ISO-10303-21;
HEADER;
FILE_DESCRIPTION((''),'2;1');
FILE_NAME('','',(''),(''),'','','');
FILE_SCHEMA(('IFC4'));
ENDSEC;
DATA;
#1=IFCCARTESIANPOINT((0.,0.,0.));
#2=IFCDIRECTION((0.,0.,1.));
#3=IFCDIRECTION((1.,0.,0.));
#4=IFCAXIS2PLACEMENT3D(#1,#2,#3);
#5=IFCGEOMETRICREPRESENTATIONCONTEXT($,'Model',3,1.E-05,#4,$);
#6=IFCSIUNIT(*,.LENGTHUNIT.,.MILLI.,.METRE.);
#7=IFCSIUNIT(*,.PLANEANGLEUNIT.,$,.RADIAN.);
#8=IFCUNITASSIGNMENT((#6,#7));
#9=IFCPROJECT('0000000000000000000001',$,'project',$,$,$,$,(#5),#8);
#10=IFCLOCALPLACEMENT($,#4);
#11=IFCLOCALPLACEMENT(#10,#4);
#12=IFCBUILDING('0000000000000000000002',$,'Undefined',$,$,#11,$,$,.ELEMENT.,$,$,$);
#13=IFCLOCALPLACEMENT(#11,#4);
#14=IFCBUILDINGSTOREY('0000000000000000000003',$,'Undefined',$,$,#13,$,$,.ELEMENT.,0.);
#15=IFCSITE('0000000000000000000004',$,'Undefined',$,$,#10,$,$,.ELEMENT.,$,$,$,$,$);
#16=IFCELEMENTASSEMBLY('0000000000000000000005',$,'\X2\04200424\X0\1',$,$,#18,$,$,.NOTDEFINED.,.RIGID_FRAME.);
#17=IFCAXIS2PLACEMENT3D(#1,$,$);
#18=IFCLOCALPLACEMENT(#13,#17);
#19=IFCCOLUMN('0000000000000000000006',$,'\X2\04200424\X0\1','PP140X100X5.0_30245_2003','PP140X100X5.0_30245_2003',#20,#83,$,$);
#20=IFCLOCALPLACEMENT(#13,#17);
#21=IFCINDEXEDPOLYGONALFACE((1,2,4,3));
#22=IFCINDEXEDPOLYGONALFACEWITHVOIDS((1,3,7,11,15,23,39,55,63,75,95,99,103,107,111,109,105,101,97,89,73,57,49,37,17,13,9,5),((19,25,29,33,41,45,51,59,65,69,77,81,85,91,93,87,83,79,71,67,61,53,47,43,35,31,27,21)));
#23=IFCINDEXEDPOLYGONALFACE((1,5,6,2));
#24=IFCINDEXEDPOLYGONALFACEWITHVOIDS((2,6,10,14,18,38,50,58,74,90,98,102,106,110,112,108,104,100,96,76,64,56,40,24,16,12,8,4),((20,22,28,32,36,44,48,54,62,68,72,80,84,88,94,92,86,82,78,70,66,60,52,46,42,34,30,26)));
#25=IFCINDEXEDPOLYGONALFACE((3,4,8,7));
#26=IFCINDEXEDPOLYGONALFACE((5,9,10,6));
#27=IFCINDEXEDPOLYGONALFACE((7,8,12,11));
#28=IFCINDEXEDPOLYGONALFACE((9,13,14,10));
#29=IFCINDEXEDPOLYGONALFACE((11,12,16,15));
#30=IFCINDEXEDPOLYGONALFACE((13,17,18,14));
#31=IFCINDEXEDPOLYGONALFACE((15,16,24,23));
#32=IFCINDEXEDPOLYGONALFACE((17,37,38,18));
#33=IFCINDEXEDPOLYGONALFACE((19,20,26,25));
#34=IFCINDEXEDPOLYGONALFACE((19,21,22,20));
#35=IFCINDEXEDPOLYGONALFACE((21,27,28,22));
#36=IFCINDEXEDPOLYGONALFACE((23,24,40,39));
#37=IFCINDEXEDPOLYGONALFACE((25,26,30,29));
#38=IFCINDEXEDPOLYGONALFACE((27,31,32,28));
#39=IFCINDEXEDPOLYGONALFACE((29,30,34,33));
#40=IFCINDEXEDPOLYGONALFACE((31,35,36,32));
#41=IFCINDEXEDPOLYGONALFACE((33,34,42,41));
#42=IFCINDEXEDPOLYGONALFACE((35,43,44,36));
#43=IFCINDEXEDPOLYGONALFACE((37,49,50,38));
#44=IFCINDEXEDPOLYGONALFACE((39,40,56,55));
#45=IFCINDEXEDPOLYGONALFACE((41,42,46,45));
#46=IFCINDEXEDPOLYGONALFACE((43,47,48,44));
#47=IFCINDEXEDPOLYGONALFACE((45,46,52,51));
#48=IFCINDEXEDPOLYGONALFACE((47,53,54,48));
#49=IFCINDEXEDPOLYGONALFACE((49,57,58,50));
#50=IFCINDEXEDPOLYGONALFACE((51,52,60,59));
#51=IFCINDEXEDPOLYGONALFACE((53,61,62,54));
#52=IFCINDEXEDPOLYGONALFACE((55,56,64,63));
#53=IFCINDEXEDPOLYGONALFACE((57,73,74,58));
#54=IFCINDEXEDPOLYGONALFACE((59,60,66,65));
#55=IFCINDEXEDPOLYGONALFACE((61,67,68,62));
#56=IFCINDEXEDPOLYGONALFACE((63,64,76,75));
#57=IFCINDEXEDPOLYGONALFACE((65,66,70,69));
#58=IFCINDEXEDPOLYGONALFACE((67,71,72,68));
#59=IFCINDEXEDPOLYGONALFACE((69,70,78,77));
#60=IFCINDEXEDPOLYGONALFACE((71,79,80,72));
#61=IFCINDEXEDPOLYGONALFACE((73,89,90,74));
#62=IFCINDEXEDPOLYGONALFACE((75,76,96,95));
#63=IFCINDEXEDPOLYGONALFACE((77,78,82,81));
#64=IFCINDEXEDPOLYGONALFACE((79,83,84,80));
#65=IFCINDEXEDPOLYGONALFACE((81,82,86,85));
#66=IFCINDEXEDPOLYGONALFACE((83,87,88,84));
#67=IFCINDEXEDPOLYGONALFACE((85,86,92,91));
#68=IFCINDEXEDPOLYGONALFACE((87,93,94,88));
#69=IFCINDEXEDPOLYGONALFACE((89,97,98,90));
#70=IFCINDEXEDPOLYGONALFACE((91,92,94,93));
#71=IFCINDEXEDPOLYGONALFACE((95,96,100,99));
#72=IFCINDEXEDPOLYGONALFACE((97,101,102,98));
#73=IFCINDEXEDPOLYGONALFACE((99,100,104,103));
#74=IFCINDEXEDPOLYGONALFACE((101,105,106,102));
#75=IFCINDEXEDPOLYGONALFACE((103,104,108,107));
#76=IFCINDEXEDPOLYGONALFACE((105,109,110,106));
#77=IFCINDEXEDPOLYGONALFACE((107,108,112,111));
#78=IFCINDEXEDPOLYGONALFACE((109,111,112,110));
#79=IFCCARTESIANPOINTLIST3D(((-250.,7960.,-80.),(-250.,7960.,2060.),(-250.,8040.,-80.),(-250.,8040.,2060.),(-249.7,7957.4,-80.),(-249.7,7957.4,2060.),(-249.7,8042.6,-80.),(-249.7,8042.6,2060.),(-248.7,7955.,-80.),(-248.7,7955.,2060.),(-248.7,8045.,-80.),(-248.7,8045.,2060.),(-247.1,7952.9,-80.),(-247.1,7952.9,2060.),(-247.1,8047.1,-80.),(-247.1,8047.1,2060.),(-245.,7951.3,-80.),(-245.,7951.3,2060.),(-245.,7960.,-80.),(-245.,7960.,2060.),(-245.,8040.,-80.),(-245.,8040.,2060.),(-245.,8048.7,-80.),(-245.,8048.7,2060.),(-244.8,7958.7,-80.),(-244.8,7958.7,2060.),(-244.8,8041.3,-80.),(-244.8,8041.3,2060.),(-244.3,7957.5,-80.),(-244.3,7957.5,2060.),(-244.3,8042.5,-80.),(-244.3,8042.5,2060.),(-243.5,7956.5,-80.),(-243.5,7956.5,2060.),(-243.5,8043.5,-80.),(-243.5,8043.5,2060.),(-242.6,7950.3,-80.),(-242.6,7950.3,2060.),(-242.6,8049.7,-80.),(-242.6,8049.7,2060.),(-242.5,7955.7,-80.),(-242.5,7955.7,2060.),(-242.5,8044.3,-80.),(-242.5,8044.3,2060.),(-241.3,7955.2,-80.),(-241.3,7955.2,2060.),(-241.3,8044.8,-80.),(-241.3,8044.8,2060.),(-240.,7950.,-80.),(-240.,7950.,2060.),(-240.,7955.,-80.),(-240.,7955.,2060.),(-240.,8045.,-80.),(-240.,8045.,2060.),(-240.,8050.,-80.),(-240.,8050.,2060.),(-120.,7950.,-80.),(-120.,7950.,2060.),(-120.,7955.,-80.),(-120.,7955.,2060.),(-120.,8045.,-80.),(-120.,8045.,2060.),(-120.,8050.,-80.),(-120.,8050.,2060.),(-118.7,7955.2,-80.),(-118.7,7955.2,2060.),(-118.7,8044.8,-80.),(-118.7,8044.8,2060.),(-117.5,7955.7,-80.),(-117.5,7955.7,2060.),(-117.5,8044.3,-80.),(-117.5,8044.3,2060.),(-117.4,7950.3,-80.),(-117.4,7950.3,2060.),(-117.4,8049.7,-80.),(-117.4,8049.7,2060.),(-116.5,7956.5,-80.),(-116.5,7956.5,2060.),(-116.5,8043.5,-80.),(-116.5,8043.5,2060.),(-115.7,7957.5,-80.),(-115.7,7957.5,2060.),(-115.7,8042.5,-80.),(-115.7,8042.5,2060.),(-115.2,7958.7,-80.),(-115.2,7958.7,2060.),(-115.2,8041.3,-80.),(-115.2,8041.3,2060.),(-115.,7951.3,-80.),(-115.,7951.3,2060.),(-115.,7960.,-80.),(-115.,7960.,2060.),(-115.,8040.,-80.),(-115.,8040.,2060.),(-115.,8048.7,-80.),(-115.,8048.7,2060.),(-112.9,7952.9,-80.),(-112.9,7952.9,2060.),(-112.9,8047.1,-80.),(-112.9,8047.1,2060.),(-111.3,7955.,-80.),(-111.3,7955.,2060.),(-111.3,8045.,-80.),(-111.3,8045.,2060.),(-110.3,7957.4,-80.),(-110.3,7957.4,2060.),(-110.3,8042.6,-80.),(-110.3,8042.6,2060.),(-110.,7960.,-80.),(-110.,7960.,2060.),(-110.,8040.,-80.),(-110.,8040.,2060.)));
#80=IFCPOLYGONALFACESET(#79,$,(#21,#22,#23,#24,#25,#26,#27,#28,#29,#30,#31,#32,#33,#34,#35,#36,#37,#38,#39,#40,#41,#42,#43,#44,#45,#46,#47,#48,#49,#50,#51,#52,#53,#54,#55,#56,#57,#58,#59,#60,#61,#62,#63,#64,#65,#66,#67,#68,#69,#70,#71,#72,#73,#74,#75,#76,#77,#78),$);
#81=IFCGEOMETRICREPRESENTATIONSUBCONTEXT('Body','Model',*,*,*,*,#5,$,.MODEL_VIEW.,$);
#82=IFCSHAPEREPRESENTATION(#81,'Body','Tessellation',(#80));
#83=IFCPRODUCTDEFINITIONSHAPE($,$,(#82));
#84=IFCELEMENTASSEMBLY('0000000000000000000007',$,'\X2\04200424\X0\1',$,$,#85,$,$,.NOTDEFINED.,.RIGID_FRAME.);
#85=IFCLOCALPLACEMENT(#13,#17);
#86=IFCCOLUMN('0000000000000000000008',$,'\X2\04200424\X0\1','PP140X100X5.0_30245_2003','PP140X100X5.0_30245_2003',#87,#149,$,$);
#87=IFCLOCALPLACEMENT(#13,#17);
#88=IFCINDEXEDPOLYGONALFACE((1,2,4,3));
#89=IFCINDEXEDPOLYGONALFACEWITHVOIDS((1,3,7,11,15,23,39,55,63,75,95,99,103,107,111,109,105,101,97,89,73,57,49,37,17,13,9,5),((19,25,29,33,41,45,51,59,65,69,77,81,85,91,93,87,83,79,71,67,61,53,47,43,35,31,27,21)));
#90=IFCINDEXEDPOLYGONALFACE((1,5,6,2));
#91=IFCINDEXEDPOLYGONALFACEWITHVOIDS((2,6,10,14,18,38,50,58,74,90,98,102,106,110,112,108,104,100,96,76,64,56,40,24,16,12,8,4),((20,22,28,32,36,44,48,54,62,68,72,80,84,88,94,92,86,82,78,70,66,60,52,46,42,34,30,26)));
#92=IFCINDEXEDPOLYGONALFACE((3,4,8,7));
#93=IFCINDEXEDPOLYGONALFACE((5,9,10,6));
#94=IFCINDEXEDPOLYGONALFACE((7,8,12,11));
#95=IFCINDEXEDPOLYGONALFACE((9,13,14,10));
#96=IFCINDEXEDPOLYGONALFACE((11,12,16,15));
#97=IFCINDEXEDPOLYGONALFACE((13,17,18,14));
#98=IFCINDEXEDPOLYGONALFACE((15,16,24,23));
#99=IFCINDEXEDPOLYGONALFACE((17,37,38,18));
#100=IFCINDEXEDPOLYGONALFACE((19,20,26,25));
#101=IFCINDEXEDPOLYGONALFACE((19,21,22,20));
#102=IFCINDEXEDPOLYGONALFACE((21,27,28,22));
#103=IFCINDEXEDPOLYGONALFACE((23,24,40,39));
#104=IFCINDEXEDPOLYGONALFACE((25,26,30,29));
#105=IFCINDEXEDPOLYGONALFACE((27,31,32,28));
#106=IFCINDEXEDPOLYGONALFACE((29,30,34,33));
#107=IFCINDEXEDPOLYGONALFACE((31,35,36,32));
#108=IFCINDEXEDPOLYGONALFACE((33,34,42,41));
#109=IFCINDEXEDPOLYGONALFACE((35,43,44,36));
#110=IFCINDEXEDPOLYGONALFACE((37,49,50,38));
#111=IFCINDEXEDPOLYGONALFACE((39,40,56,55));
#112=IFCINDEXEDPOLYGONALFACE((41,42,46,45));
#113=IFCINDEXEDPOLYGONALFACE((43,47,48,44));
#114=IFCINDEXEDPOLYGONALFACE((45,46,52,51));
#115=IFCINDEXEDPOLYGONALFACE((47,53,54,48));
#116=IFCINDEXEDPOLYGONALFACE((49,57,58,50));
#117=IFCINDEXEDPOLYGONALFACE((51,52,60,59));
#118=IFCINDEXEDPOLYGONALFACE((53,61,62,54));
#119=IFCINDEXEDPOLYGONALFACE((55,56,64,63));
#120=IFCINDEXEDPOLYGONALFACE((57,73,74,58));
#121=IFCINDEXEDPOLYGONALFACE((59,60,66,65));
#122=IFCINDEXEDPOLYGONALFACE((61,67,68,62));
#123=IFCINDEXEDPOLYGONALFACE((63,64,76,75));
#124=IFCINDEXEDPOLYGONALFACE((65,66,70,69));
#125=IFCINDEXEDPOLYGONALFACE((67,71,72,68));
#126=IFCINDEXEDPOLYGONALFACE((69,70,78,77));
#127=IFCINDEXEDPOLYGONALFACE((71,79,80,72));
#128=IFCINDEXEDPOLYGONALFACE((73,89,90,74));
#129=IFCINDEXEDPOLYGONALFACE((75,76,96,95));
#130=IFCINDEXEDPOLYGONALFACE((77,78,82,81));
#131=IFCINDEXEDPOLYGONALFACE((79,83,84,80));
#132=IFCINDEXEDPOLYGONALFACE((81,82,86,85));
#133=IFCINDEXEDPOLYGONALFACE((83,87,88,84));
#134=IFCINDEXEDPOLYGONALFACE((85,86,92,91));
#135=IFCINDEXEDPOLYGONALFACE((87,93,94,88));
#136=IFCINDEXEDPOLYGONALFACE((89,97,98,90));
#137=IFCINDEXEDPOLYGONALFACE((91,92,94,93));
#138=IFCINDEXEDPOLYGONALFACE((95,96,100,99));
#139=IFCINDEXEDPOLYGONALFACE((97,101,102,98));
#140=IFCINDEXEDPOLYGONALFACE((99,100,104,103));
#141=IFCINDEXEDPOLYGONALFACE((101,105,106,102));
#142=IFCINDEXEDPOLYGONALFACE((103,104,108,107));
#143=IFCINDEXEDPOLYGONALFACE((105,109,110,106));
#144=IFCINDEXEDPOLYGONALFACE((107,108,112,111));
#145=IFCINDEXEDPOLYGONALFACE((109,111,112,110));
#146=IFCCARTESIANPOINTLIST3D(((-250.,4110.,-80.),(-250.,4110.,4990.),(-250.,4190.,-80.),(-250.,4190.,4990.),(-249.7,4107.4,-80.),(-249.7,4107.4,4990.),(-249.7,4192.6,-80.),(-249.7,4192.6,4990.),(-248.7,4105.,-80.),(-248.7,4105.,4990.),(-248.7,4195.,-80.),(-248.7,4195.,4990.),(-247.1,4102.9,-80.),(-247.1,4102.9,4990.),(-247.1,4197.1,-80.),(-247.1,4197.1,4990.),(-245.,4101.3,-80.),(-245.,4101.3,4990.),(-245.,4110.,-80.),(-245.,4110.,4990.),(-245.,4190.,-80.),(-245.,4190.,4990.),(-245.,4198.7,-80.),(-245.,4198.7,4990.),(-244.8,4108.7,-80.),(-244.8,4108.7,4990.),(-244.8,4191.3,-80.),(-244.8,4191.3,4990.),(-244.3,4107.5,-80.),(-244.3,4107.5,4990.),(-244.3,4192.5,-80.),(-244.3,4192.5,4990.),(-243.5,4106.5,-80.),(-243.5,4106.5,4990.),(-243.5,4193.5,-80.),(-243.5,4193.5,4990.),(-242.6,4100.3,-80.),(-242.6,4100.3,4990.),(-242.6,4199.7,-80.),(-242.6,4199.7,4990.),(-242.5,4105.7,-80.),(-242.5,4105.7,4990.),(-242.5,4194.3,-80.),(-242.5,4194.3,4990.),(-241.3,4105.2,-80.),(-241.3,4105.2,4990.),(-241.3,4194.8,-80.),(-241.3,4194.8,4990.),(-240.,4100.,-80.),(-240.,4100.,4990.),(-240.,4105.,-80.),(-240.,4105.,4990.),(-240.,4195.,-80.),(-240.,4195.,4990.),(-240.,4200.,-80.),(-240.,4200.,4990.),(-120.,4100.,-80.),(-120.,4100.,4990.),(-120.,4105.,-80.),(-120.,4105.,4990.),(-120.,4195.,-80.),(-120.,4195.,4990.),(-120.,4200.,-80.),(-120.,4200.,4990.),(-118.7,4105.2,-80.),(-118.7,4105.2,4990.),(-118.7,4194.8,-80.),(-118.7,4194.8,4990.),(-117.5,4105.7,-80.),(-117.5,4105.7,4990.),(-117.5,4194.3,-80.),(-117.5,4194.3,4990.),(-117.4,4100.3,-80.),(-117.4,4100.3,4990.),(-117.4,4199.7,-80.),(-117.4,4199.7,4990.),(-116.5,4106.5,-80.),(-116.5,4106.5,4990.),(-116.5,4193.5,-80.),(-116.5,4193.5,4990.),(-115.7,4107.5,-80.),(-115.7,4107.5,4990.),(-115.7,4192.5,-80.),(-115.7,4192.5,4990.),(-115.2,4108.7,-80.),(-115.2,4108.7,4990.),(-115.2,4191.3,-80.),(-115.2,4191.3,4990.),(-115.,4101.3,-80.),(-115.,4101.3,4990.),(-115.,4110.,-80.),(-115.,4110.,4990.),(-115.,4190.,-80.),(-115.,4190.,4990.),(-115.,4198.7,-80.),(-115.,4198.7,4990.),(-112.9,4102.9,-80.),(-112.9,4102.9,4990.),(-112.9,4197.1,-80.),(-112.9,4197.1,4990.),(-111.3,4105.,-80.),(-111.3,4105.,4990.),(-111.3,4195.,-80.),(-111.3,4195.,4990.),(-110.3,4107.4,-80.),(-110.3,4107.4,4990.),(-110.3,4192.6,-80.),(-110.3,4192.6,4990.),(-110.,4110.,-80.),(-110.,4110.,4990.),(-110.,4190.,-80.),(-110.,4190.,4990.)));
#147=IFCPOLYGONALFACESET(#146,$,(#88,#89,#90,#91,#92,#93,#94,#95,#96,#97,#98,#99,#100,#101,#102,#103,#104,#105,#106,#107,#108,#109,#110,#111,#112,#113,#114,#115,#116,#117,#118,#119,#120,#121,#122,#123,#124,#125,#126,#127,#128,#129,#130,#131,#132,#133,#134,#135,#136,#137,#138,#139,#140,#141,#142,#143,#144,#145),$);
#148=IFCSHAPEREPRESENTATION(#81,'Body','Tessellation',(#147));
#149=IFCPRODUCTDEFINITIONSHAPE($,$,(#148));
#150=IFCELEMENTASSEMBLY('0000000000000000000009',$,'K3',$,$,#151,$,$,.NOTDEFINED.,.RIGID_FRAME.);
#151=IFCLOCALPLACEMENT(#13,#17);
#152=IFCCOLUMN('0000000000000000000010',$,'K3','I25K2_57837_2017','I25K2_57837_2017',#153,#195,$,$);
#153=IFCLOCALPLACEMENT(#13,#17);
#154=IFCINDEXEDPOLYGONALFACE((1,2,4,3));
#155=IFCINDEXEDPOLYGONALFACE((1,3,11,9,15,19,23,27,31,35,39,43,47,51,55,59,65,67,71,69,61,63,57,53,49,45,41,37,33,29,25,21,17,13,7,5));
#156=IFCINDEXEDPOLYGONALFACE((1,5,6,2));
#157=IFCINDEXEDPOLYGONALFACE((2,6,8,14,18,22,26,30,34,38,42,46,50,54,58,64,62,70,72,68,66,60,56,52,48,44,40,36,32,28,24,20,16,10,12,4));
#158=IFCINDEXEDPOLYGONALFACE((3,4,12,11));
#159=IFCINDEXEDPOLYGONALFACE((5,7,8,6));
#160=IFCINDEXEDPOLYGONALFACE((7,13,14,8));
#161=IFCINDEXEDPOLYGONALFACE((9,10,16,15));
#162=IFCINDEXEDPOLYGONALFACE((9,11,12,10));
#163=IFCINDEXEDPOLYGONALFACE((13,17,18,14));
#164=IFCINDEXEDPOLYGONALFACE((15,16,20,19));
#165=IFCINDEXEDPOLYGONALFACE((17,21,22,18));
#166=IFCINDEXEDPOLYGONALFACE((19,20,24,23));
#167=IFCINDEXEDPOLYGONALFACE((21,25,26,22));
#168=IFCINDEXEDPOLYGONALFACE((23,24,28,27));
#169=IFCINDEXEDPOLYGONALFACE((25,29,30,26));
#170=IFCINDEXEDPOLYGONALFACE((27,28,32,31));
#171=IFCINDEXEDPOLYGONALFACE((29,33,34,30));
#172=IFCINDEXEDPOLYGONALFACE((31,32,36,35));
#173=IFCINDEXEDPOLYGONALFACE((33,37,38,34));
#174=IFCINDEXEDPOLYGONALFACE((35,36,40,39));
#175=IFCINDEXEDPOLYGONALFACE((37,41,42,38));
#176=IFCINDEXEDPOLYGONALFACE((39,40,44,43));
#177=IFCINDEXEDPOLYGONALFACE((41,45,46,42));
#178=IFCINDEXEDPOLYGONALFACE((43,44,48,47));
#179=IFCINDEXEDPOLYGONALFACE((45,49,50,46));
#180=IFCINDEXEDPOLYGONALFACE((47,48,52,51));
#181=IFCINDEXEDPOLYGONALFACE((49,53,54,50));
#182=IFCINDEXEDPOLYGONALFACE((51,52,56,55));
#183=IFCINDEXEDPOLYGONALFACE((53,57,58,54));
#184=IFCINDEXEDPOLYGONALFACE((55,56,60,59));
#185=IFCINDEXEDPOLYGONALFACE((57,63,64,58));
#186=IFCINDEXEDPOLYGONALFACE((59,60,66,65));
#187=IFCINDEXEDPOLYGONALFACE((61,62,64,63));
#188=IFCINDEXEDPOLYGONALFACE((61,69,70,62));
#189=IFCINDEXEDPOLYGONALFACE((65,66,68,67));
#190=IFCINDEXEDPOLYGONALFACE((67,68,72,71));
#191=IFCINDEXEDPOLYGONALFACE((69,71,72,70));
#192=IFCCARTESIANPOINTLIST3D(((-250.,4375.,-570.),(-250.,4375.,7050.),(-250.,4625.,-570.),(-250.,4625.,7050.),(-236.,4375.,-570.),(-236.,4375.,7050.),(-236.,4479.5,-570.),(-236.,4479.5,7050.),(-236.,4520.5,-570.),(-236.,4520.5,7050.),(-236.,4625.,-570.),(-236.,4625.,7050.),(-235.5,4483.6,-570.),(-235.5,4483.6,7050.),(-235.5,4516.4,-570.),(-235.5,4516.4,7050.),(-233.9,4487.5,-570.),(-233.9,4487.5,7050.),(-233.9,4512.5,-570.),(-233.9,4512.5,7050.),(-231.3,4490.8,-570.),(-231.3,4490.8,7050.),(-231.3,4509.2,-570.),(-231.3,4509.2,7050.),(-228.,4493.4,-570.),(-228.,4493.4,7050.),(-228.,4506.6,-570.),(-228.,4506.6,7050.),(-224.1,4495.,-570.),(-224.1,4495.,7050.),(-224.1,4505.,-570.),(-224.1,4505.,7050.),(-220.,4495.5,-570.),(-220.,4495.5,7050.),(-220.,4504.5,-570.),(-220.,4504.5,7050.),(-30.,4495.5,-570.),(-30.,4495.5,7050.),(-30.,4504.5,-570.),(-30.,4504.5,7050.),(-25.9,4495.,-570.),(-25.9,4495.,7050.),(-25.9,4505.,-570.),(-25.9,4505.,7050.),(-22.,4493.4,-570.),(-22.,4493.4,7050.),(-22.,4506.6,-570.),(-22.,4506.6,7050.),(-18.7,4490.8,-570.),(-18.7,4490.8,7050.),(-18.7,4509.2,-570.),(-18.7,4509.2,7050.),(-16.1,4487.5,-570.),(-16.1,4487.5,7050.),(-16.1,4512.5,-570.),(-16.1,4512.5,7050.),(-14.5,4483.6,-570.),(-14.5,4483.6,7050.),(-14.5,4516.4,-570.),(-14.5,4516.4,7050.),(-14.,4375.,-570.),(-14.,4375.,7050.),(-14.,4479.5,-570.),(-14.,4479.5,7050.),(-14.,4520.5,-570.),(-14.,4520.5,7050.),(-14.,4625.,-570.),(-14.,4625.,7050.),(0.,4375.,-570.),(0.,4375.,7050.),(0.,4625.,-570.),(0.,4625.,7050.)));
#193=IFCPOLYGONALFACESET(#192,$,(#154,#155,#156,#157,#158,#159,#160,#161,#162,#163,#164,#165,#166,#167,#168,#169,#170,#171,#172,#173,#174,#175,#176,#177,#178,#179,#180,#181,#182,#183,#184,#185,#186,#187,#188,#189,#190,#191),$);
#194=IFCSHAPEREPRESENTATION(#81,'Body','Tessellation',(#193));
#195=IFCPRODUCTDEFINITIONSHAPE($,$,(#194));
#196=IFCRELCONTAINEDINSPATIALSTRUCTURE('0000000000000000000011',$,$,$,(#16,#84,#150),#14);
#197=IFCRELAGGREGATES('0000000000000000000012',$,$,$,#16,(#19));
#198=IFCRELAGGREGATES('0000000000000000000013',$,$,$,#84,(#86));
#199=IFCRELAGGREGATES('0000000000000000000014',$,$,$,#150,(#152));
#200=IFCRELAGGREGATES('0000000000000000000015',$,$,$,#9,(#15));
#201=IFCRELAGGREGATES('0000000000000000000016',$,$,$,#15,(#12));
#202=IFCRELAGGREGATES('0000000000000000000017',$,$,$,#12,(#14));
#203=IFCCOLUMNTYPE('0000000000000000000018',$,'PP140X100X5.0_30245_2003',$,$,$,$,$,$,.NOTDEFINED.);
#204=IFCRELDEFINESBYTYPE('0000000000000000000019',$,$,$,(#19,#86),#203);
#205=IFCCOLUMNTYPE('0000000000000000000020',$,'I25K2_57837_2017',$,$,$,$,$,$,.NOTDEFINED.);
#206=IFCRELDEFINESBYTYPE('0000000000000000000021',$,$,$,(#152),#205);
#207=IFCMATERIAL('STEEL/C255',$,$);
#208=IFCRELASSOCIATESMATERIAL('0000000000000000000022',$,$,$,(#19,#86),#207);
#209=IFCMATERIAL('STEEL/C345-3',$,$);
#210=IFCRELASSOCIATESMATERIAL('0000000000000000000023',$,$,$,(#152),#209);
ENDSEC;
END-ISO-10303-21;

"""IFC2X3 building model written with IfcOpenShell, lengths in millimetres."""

from ifc_helpers import new_model, si_unit, frame, origin_with_axes, origin_2d_with_axis, place, context, subcontext, project, spatial, hollow_rectangle, i_section, extrude, material, type_object, element, aggregate, save


model = new_model("IFC2X3")

# Units and contexts
model_context = context("Model", 3, precision=1e-05, world=origin_with_axes())
body_context = subcontext(model_context, "Body", "Model", "MODEL_VIEW")
ifc_project = project(units=[si_unit("LENGTHUNIT", "METRE", prefix="MILLI"), si_unit("PLANEANGLEUNIT", "RADIAN")], contexts=[model_context])

# Site, building, storey
site_placement = place(None, origin_with_axes())
site = spatial("IfcSite", under=ifc_project, at=site_placement, Name="Undefined", CompositionType="ELEMENT")
building_placement = place(site_placement, origin_with_axes())
building = spatial("IfcBuilding", under=site, at=building_placement, Name="Undefined", CompositionType="ELEMENT")
storey_placement = place(building_placement, origin_with_axes())
storey = spatial("IfcBuildingStorey", under=building, at=storey_placement, Name="Undefined", CompositionType="ELEMENT", Elevation=0.0)

# Element assemblies, columns
assembly_1_placement = place(storey_placement, origin_with_axes())
assembly_1 = element("IfcElementAssembly", 1, at=assembly_1_placement, inside=storey, Name="РФ1", AssemblyPlace="NOTDEFINED", PredefinedType="RIGID_FRAME")
ifc_material_1 = material(Name="STEEL/C255")
column_type_1 = type_object("IfcColumnType", Name="PP140X100X5.0_30245_2003", PredefinedType="NOTDEFINED")
column_1_placement = place(assembly_1_placement, frame((-180.0, 8000.0, -80.0), z_axis=(0.0, 0.0, 1.0), x_axis=(1.0, 0.0, 0.0)))
column_1 = element("IfcColumn", 2, at=column_1_placement, type_object=column_type_1, material=ifc_material_1, Name="РФ1", Description="PP140X100X5.0_30245_2003", ObjectType="PP140X100X5.0_30245_2003", context=body_context, shape_type="SweptSolid", body=[
    extrude(hollow_rectangle(XDim=100.0, YDim=140.0, WallThickness=5.0, InnerFilletRadius=5.0, OuterFilletRadius=10.0, at=origin_2d_with_axis()), frame((0.0, 0.0, 2140.0), z_axis=(0.0, 0.0, -1.0), x_axis=(0.0, 1.0, 0.0)), (0.0, 0.0, 1.0), 2140.0),
])
aggregate(assembly_1, [column_1])
assembly_2_placement = place(storey_placement, origin_with_axes())
assembly_2 = element("IfcElementAssembly", 3, at=assembly_2_placement, inside=storey, Name="РФ1", AssemblyPlace="NOTDEFINED", PredefinedType="RIGID_FRAME")
column_2_placement = place(assembly_2_placement, frame((-180.0, 4150.0, -80.0), z_axis=(0.0, 0.0, 1.0), x_axis=(1.0, 0.0, 0.0)))
column_2 = element("IfcColumn", 4, at=column_2_placement, type_object=column_type_1, material=ifc_material_1, Name="РФ1", Description="PP140X100X5.0_30245_2003", ObjectType="PP140X100X5.0_30245_2003", context=body_context, shape_type="SweptSolid", body=[
    extrude(hollow_rectangle(XDim=100.0, YDim=140.0, WallThickness=5.0, InnerFilletRadius=5.0, OuterFilletRadius=10.0, at=origin_2d_with_axis()), frame((0.0, 0.0, 5070.0), z_axis=(0.0, 0.0, -1.0), x_axis=(0.0, 1.0, 0.0)), (0.0, 0.0, 1.0), 5070.0),
])
aggregate(assembly_2, [column_2])
assembly_3_placement = place(storey_placement, origin_with_axes())
assembly_3 = element("IfcElementAssembly", 5, at=assembly_3_placement, inside=storey, Name="K3", AssemblyPlace="NOTDEFINED", PredefinedType="RIGID_FRAME")
ifc_material_2 = material(Name="STEEL/C345-3")
column_type_2 = type_object("IfcColumnType", Name="I25K2_57837_2017", PredefinedType="NOTDEFINED")
column_3_placement = place(assembly_3_placement, frame((-125.0, 4500.0, -570.0), z_axis=(0.0, 0.0, 1.0), x_axis=(-1.0, 0.0, 0.0)))
column_3 = element("IfcColumn", 6, at=column_3_placement, type_object=column_type_2, material=ifc_material_2, Name="K3", Description="I25K2_57837_2017", ObjectType="I25K2_57837_2017", context=body_context, shape_type="SweptSolid", body=[
    extrude(i_section(OverallWidth=250.0, OverallDepth=250.0, WebThickness=9.0, FlangeThickness=14.0, FilletRadius=16.0, at=origin_2d_with_axis()), frame((0.0, 0.0, 7620.0), z_axis=(0.0, 0.0, -1.0), x_axis=(0.0, 1.0, 0.0)), (0.0, 0.0, 1.0), 7620.0),
])
aggregate(assembly_3, [column_3])

save(model, "model.ifc")
